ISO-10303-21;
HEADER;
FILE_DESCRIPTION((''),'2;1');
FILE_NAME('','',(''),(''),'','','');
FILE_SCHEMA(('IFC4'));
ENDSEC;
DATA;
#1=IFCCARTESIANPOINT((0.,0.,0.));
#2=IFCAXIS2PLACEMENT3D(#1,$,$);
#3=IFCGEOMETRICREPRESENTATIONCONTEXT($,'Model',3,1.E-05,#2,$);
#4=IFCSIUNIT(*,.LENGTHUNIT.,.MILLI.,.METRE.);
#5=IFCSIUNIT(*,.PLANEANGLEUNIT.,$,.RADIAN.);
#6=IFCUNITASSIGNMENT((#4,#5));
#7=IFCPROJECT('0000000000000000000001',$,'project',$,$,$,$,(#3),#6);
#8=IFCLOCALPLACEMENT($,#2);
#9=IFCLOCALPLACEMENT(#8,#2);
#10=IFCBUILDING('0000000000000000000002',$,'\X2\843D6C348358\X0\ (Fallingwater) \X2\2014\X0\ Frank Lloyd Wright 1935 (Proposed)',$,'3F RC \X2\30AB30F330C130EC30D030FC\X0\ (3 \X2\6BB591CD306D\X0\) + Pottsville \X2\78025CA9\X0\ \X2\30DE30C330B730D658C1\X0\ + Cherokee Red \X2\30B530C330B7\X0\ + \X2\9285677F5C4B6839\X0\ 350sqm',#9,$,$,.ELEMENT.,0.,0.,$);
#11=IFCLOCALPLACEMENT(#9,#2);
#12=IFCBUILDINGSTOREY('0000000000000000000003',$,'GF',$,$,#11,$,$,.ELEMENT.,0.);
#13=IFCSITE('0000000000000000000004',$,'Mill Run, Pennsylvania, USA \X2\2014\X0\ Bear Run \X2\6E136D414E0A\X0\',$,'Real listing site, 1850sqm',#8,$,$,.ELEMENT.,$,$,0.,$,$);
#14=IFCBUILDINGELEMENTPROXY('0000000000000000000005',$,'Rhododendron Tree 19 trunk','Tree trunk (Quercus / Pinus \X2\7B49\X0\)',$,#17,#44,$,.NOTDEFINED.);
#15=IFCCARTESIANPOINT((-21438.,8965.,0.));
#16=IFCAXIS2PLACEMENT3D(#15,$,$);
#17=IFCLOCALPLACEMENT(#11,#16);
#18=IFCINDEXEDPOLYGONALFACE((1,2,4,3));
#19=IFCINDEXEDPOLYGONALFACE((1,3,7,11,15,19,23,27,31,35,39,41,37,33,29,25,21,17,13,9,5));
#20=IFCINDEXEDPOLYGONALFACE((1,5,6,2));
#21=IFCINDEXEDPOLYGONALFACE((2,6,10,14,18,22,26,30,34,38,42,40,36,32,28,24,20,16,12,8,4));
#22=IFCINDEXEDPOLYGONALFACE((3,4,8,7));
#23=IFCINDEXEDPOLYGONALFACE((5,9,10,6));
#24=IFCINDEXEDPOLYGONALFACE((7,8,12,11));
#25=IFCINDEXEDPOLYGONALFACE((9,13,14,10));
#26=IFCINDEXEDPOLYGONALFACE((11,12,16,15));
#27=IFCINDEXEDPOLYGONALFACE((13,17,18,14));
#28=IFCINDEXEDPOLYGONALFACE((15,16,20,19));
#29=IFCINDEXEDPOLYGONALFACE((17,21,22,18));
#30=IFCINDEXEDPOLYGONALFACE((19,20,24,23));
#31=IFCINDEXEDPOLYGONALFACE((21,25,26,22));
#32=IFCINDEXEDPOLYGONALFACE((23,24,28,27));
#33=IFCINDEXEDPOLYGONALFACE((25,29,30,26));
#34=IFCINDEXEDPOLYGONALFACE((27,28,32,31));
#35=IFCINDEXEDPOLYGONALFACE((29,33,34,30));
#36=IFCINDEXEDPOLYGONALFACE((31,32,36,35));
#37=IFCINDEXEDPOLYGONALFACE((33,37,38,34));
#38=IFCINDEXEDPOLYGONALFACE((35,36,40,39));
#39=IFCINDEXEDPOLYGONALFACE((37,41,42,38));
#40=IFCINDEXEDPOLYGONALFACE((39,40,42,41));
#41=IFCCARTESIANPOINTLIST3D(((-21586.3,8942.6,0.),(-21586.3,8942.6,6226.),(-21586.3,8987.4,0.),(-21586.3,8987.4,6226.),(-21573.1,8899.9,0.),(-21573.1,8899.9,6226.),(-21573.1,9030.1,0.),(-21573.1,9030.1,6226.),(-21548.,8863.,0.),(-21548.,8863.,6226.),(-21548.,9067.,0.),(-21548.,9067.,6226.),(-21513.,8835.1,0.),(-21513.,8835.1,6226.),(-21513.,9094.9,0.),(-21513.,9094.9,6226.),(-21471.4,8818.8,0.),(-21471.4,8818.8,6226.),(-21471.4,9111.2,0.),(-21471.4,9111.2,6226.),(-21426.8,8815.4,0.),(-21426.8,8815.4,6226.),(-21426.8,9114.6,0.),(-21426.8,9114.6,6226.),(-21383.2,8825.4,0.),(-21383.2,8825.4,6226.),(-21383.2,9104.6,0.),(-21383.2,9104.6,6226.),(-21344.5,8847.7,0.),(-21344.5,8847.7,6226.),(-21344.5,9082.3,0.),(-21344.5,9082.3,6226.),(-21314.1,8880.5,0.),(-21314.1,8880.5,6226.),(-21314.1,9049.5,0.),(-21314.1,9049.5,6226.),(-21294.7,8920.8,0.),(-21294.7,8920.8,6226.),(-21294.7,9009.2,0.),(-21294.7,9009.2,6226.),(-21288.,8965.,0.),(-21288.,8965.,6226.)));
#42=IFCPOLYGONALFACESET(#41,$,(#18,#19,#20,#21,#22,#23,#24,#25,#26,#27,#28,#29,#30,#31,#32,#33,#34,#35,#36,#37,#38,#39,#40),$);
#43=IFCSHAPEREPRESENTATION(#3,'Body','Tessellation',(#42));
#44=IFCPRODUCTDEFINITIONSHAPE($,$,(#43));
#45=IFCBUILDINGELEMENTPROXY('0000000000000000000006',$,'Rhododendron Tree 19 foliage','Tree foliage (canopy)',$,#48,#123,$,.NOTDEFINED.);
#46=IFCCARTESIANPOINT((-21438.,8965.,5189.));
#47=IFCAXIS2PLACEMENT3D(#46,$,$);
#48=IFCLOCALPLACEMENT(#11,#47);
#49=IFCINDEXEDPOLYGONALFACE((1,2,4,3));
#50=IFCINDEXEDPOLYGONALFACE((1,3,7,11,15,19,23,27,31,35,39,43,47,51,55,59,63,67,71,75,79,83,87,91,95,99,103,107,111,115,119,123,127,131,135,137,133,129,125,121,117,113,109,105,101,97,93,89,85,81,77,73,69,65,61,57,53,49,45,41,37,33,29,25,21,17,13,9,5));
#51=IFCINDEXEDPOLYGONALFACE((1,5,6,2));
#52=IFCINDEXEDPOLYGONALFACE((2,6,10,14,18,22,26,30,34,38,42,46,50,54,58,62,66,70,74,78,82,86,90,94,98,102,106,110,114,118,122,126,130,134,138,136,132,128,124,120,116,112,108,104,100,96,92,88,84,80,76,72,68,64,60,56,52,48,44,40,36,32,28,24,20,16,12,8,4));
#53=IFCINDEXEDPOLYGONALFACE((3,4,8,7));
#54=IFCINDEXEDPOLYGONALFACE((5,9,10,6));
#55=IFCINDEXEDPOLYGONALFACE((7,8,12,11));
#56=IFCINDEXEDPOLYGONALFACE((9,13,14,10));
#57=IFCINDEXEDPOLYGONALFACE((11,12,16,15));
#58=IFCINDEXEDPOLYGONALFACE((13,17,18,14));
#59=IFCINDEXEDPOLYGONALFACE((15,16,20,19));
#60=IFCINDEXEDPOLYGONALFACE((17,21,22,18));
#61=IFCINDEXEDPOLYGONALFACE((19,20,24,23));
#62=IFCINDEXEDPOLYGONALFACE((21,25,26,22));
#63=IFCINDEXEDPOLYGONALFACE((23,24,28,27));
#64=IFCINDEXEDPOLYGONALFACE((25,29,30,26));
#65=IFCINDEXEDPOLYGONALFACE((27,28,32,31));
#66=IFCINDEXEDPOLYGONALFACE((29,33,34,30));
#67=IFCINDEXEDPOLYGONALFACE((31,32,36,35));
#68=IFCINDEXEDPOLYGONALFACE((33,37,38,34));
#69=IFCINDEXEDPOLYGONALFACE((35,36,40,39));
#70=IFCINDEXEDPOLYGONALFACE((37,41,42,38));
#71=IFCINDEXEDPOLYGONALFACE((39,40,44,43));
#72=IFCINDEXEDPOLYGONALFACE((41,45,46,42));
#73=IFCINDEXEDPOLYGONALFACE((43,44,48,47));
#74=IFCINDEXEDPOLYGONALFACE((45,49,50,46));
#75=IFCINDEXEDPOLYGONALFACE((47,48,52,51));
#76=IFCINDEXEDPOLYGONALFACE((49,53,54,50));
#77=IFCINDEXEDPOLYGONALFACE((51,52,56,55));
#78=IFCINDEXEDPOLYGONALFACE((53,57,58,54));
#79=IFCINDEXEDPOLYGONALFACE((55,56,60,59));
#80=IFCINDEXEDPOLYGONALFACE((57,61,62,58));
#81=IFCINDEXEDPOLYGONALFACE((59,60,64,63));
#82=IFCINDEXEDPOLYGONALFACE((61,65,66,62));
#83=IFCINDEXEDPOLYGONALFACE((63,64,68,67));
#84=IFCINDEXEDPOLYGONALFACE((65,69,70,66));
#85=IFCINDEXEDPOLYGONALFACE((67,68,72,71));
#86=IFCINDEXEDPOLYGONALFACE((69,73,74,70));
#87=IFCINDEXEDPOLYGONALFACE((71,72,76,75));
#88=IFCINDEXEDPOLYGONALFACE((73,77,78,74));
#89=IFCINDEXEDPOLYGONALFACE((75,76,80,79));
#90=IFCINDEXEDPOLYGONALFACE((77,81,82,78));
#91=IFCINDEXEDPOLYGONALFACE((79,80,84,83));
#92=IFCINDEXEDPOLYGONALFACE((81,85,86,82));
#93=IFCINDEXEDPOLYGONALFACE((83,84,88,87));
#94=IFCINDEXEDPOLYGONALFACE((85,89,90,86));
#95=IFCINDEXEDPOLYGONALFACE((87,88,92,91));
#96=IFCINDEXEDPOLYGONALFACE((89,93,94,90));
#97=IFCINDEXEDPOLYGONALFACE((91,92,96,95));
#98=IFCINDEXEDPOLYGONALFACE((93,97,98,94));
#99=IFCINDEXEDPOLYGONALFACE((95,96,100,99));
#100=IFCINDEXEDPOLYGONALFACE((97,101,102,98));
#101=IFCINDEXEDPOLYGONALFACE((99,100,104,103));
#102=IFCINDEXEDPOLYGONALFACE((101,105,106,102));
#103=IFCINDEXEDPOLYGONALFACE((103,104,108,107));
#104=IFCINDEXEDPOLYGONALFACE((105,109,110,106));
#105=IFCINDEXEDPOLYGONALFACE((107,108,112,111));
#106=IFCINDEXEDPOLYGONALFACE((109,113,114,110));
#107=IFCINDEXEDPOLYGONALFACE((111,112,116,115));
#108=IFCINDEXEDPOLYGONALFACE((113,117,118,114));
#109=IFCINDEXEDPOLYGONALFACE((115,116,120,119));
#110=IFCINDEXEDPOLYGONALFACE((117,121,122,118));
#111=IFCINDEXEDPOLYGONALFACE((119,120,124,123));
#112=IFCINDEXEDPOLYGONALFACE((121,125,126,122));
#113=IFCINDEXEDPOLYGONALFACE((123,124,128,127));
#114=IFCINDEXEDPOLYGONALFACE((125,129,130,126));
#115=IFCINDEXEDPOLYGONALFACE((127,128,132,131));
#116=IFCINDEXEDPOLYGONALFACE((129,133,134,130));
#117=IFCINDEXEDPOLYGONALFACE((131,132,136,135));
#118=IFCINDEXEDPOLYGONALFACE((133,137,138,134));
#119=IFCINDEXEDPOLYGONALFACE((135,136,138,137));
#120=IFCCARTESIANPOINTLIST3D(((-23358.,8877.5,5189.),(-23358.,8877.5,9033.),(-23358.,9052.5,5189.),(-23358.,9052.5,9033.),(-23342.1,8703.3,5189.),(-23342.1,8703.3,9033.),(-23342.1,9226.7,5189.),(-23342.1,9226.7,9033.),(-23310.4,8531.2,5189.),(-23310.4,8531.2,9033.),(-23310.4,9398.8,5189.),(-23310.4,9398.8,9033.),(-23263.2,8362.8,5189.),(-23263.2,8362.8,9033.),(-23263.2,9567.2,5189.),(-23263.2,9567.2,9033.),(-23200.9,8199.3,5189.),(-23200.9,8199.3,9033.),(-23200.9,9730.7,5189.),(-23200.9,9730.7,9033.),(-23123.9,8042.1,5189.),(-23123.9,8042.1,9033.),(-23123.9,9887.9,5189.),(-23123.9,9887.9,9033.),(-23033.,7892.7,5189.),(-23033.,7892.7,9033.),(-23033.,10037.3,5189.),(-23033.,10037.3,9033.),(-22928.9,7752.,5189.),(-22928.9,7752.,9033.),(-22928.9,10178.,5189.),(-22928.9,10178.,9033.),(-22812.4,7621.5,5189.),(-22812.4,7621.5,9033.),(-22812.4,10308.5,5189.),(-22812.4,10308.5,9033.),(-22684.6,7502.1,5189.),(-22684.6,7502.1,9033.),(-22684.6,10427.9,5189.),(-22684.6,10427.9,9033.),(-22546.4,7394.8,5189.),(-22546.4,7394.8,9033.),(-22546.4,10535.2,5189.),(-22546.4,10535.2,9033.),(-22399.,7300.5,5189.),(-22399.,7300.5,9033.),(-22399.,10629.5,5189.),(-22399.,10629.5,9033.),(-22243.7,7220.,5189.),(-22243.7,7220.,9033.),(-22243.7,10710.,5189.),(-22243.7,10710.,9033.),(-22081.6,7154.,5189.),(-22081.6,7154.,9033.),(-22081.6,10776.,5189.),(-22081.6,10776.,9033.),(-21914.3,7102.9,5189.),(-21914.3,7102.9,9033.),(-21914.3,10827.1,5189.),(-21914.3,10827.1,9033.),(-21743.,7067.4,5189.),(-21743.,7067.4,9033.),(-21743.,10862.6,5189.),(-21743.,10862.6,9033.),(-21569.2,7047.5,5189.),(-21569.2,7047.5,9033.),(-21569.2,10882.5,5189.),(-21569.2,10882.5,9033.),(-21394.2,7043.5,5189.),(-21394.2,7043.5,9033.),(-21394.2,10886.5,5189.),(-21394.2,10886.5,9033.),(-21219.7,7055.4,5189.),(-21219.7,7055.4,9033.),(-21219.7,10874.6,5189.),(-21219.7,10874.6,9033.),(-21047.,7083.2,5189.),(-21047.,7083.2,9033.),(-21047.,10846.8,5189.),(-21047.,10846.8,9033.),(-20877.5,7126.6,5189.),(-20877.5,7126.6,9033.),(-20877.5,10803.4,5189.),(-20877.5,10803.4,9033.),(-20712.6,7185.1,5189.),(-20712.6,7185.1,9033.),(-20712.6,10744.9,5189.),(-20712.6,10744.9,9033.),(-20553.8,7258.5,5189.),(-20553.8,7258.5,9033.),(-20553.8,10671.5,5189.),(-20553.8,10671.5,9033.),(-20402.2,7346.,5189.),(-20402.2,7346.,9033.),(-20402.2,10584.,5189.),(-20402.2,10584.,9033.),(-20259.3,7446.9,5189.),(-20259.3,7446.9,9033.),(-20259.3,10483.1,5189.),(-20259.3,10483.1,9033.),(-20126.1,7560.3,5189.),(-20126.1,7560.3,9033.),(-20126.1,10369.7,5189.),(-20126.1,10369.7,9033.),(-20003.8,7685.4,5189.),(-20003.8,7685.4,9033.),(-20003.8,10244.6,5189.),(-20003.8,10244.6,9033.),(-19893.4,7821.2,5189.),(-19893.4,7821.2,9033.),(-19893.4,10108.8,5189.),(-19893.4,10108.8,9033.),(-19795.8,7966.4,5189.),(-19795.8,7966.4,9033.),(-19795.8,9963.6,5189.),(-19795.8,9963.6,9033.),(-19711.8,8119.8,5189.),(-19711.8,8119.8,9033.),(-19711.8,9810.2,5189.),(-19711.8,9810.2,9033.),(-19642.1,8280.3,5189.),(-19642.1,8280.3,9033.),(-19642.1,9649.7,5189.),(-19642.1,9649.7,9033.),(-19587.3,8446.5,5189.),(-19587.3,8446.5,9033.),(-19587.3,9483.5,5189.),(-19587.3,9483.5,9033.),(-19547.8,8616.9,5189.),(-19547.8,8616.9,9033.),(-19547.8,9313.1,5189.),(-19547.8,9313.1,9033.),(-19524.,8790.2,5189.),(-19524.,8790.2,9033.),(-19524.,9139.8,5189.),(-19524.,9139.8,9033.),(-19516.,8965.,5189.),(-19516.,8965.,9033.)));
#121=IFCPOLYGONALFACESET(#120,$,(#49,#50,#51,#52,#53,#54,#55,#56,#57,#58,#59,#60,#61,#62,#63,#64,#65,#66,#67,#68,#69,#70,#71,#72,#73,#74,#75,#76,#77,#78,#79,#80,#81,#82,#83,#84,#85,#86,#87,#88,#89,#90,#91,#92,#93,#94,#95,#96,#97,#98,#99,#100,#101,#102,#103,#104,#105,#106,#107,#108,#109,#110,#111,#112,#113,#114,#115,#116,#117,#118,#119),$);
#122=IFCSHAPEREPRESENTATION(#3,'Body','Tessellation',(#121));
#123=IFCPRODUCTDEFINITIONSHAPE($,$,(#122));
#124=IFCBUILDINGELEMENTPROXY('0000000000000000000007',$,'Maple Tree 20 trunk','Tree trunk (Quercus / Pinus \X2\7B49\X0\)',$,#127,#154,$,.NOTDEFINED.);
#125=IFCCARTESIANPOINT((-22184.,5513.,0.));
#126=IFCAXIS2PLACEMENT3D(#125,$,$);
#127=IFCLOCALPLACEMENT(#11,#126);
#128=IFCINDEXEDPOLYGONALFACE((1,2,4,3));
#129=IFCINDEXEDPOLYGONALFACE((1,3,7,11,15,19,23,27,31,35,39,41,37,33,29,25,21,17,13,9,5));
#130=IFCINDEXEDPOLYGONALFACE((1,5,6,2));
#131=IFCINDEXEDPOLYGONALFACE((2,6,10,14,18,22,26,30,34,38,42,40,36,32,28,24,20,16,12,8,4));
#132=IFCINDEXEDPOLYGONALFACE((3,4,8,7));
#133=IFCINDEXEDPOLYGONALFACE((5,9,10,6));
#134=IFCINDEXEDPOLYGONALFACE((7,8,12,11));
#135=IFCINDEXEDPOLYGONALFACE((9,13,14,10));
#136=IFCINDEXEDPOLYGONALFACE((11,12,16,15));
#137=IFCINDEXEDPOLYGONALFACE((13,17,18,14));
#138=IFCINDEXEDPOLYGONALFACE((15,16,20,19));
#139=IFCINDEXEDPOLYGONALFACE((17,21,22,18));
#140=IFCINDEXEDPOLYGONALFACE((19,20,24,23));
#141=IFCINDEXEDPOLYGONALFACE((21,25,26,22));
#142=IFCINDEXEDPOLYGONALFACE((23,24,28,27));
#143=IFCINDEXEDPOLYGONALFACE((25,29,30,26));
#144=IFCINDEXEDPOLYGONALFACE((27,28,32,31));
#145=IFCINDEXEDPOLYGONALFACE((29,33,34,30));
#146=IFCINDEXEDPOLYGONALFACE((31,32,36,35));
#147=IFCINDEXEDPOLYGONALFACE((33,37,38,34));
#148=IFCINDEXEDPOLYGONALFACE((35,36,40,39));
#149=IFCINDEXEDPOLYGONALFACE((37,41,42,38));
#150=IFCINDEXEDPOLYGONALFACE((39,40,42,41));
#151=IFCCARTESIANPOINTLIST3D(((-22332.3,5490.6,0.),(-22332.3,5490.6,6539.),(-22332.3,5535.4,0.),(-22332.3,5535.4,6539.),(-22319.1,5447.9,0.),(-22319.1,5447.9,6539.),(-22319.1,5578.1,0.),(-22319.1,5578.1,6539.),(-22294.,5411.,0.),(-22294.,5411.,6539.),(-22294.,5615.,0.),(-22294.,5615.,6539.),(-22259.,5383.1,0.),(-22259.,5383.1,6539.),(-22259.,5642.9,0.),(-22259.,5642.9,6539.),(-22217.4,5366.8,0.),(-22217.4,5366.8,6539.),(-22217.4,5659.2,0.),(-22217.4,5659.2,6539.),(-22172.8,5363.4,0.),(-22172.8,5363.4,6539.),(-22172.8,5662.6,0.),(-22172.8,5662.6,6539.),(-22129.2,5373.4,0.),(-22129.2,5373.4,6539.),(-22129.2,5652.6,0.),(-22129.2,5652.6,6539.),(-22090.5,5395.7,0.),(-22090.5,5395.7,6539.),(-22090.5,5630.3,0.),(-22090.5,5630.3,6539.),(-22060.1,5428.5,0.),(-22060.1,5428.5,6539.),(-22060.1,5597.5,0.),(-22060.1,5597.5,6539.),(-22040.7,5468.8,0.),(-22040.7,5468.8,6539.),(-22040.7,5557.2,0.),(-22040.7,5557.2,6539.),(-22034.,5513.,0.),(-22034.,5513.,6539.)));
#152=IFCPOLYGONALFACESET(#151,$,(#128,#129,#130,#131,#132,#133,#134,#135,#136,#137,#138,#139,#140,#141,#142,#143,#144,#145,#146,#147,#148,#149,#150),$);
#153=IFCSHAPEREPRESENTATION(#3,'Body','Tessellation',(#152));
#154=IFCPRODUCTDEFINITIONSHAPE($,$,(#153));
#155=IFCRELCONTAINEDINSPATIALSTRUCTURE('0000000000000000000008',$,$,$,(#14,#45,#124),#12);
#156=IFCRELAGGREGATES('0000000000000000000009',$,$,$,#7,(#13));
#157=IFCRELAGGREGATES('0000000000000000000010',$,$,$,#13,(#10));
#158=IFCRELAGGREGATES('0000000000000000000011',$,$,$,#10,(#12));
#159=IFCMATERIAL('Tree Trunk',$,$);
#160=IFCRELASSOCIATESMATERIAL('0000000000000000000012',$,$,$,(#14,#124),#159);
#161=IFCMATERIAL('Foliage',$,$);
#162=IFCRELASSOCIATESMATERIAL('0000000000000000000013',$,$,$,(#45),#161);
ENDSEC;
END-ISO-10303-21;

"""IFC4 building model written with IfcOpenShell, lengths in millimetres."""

from ifc_helpers import new_model, si_unit, frame, origin, origin_2d, place, context, project, spatial, circle, extrude, material, element, save


model = new_model("IFC4")

# Units and contexts
model_context = context("Model", 3, precision=1e-05, world=origin())
ifc_project = project(units=[si_unit("LENGTHUNIT", "METRE", prefix="MILLI"), si_unit("PLANEANGLEUNIT", "RADIAN")], contexts=[model_context])

# Site, building, storey
site_placement = place(None, origin())
site = spatial("IfcSite", under=ifc_project, at=site_placement, Name="Mill Run, Pennsylvania, USA — Bear Run 渓流上", ObjectType="Real listing site, 1850sqm", CompositionType="ELEMENT", RefElevation=0.0)
building_placement = place(site_placement, origin())
building = spatial("IfcBuilding", under=site, at=building_placement, Name="落水荘 (Fallingwater) — Frank Lloyd Wright 1935 (Proposed)", ObjectType="3F RC カンチレバー (3 段重ね) + Pottsville 砂岩 マッシブ壁 + Cherokee Red サッシ + 銅板屋根 350sqm", CompositionType="ELEMENT", ElevationOfRefHeight=0.0, ElevationOfTerrain=0.0)
storey_placement = place(building_placement, origin())
storey = spatial("IfcBuildingStorey", under=building, at=storey_placement, Name="GF", CompositionType="ELEMENT", Elevation=0.0)

# Building element proxies
ifc_material_1 = material(Name="Tree Trunk")
ifc_material_2 = material(Name="Foliage")
proxy_1_placement = place(storey_placement, frame((-21438.0, 8965.0, 0.0)))
element("IfcBuildingElementProxy", 1, at=proxy_1_placement, inside=storey, material=ifc_material_1, Name="Rhododendron Tree 19 trunk", Description="Tree trunk (Quercus / Pinus 等)", PredefinedType="NOTDEFINED", context=model_context, shape_type="SweptSolid", body=[
    extrude(circle(Radius=150.0, at=origin_2d()), frame((-21438.0, 8965.0, 0.0)), (0.0, 0.0, 1.0), 6226.0),
])
proxy_2_placement = place(storey_placement, frame((-21438.0, 8965.0, 5189.0)))
element("IfcBuildingElementProxy", 2, at=proxy_2_placement, inside=storey, material=ifc_material_2, Name="Rhododendron Tree 19 foliage", Description="Tree foliage (canopy)", PredefinedType="NOTDEFINED", context=model_context, shape_type="SweptSolid", body=[
    extrude(circle(Radius=1922.0, at=origin_2d()), frame((-21438.0, 8965.0, 5189.0)), (0.0, 0.0, 1.0), 3844.0),
])
proxy_3_placement = place(storey_placement, frame((-22184.0, 5513.0, 0.0)))
element("IfcBuildingElementProxy", 3, at=proxy_3_placement, inside=storey, material=ifc_material_1, Name="Maple Tree 20 trunk", Description="Tree trunk (Quercus / Pinus 等)", PredefinedType="NOTDEFINED", context=model_context, shape_type="SweptSolid", body=[
    extrude(circle(Radius=150.0, at=origin_2d()), frame((-22184.0, 5513.0, 0.0)), (0.0, 0.0, 1.0), 6539.0),
])

save(model, "model.ifc")
